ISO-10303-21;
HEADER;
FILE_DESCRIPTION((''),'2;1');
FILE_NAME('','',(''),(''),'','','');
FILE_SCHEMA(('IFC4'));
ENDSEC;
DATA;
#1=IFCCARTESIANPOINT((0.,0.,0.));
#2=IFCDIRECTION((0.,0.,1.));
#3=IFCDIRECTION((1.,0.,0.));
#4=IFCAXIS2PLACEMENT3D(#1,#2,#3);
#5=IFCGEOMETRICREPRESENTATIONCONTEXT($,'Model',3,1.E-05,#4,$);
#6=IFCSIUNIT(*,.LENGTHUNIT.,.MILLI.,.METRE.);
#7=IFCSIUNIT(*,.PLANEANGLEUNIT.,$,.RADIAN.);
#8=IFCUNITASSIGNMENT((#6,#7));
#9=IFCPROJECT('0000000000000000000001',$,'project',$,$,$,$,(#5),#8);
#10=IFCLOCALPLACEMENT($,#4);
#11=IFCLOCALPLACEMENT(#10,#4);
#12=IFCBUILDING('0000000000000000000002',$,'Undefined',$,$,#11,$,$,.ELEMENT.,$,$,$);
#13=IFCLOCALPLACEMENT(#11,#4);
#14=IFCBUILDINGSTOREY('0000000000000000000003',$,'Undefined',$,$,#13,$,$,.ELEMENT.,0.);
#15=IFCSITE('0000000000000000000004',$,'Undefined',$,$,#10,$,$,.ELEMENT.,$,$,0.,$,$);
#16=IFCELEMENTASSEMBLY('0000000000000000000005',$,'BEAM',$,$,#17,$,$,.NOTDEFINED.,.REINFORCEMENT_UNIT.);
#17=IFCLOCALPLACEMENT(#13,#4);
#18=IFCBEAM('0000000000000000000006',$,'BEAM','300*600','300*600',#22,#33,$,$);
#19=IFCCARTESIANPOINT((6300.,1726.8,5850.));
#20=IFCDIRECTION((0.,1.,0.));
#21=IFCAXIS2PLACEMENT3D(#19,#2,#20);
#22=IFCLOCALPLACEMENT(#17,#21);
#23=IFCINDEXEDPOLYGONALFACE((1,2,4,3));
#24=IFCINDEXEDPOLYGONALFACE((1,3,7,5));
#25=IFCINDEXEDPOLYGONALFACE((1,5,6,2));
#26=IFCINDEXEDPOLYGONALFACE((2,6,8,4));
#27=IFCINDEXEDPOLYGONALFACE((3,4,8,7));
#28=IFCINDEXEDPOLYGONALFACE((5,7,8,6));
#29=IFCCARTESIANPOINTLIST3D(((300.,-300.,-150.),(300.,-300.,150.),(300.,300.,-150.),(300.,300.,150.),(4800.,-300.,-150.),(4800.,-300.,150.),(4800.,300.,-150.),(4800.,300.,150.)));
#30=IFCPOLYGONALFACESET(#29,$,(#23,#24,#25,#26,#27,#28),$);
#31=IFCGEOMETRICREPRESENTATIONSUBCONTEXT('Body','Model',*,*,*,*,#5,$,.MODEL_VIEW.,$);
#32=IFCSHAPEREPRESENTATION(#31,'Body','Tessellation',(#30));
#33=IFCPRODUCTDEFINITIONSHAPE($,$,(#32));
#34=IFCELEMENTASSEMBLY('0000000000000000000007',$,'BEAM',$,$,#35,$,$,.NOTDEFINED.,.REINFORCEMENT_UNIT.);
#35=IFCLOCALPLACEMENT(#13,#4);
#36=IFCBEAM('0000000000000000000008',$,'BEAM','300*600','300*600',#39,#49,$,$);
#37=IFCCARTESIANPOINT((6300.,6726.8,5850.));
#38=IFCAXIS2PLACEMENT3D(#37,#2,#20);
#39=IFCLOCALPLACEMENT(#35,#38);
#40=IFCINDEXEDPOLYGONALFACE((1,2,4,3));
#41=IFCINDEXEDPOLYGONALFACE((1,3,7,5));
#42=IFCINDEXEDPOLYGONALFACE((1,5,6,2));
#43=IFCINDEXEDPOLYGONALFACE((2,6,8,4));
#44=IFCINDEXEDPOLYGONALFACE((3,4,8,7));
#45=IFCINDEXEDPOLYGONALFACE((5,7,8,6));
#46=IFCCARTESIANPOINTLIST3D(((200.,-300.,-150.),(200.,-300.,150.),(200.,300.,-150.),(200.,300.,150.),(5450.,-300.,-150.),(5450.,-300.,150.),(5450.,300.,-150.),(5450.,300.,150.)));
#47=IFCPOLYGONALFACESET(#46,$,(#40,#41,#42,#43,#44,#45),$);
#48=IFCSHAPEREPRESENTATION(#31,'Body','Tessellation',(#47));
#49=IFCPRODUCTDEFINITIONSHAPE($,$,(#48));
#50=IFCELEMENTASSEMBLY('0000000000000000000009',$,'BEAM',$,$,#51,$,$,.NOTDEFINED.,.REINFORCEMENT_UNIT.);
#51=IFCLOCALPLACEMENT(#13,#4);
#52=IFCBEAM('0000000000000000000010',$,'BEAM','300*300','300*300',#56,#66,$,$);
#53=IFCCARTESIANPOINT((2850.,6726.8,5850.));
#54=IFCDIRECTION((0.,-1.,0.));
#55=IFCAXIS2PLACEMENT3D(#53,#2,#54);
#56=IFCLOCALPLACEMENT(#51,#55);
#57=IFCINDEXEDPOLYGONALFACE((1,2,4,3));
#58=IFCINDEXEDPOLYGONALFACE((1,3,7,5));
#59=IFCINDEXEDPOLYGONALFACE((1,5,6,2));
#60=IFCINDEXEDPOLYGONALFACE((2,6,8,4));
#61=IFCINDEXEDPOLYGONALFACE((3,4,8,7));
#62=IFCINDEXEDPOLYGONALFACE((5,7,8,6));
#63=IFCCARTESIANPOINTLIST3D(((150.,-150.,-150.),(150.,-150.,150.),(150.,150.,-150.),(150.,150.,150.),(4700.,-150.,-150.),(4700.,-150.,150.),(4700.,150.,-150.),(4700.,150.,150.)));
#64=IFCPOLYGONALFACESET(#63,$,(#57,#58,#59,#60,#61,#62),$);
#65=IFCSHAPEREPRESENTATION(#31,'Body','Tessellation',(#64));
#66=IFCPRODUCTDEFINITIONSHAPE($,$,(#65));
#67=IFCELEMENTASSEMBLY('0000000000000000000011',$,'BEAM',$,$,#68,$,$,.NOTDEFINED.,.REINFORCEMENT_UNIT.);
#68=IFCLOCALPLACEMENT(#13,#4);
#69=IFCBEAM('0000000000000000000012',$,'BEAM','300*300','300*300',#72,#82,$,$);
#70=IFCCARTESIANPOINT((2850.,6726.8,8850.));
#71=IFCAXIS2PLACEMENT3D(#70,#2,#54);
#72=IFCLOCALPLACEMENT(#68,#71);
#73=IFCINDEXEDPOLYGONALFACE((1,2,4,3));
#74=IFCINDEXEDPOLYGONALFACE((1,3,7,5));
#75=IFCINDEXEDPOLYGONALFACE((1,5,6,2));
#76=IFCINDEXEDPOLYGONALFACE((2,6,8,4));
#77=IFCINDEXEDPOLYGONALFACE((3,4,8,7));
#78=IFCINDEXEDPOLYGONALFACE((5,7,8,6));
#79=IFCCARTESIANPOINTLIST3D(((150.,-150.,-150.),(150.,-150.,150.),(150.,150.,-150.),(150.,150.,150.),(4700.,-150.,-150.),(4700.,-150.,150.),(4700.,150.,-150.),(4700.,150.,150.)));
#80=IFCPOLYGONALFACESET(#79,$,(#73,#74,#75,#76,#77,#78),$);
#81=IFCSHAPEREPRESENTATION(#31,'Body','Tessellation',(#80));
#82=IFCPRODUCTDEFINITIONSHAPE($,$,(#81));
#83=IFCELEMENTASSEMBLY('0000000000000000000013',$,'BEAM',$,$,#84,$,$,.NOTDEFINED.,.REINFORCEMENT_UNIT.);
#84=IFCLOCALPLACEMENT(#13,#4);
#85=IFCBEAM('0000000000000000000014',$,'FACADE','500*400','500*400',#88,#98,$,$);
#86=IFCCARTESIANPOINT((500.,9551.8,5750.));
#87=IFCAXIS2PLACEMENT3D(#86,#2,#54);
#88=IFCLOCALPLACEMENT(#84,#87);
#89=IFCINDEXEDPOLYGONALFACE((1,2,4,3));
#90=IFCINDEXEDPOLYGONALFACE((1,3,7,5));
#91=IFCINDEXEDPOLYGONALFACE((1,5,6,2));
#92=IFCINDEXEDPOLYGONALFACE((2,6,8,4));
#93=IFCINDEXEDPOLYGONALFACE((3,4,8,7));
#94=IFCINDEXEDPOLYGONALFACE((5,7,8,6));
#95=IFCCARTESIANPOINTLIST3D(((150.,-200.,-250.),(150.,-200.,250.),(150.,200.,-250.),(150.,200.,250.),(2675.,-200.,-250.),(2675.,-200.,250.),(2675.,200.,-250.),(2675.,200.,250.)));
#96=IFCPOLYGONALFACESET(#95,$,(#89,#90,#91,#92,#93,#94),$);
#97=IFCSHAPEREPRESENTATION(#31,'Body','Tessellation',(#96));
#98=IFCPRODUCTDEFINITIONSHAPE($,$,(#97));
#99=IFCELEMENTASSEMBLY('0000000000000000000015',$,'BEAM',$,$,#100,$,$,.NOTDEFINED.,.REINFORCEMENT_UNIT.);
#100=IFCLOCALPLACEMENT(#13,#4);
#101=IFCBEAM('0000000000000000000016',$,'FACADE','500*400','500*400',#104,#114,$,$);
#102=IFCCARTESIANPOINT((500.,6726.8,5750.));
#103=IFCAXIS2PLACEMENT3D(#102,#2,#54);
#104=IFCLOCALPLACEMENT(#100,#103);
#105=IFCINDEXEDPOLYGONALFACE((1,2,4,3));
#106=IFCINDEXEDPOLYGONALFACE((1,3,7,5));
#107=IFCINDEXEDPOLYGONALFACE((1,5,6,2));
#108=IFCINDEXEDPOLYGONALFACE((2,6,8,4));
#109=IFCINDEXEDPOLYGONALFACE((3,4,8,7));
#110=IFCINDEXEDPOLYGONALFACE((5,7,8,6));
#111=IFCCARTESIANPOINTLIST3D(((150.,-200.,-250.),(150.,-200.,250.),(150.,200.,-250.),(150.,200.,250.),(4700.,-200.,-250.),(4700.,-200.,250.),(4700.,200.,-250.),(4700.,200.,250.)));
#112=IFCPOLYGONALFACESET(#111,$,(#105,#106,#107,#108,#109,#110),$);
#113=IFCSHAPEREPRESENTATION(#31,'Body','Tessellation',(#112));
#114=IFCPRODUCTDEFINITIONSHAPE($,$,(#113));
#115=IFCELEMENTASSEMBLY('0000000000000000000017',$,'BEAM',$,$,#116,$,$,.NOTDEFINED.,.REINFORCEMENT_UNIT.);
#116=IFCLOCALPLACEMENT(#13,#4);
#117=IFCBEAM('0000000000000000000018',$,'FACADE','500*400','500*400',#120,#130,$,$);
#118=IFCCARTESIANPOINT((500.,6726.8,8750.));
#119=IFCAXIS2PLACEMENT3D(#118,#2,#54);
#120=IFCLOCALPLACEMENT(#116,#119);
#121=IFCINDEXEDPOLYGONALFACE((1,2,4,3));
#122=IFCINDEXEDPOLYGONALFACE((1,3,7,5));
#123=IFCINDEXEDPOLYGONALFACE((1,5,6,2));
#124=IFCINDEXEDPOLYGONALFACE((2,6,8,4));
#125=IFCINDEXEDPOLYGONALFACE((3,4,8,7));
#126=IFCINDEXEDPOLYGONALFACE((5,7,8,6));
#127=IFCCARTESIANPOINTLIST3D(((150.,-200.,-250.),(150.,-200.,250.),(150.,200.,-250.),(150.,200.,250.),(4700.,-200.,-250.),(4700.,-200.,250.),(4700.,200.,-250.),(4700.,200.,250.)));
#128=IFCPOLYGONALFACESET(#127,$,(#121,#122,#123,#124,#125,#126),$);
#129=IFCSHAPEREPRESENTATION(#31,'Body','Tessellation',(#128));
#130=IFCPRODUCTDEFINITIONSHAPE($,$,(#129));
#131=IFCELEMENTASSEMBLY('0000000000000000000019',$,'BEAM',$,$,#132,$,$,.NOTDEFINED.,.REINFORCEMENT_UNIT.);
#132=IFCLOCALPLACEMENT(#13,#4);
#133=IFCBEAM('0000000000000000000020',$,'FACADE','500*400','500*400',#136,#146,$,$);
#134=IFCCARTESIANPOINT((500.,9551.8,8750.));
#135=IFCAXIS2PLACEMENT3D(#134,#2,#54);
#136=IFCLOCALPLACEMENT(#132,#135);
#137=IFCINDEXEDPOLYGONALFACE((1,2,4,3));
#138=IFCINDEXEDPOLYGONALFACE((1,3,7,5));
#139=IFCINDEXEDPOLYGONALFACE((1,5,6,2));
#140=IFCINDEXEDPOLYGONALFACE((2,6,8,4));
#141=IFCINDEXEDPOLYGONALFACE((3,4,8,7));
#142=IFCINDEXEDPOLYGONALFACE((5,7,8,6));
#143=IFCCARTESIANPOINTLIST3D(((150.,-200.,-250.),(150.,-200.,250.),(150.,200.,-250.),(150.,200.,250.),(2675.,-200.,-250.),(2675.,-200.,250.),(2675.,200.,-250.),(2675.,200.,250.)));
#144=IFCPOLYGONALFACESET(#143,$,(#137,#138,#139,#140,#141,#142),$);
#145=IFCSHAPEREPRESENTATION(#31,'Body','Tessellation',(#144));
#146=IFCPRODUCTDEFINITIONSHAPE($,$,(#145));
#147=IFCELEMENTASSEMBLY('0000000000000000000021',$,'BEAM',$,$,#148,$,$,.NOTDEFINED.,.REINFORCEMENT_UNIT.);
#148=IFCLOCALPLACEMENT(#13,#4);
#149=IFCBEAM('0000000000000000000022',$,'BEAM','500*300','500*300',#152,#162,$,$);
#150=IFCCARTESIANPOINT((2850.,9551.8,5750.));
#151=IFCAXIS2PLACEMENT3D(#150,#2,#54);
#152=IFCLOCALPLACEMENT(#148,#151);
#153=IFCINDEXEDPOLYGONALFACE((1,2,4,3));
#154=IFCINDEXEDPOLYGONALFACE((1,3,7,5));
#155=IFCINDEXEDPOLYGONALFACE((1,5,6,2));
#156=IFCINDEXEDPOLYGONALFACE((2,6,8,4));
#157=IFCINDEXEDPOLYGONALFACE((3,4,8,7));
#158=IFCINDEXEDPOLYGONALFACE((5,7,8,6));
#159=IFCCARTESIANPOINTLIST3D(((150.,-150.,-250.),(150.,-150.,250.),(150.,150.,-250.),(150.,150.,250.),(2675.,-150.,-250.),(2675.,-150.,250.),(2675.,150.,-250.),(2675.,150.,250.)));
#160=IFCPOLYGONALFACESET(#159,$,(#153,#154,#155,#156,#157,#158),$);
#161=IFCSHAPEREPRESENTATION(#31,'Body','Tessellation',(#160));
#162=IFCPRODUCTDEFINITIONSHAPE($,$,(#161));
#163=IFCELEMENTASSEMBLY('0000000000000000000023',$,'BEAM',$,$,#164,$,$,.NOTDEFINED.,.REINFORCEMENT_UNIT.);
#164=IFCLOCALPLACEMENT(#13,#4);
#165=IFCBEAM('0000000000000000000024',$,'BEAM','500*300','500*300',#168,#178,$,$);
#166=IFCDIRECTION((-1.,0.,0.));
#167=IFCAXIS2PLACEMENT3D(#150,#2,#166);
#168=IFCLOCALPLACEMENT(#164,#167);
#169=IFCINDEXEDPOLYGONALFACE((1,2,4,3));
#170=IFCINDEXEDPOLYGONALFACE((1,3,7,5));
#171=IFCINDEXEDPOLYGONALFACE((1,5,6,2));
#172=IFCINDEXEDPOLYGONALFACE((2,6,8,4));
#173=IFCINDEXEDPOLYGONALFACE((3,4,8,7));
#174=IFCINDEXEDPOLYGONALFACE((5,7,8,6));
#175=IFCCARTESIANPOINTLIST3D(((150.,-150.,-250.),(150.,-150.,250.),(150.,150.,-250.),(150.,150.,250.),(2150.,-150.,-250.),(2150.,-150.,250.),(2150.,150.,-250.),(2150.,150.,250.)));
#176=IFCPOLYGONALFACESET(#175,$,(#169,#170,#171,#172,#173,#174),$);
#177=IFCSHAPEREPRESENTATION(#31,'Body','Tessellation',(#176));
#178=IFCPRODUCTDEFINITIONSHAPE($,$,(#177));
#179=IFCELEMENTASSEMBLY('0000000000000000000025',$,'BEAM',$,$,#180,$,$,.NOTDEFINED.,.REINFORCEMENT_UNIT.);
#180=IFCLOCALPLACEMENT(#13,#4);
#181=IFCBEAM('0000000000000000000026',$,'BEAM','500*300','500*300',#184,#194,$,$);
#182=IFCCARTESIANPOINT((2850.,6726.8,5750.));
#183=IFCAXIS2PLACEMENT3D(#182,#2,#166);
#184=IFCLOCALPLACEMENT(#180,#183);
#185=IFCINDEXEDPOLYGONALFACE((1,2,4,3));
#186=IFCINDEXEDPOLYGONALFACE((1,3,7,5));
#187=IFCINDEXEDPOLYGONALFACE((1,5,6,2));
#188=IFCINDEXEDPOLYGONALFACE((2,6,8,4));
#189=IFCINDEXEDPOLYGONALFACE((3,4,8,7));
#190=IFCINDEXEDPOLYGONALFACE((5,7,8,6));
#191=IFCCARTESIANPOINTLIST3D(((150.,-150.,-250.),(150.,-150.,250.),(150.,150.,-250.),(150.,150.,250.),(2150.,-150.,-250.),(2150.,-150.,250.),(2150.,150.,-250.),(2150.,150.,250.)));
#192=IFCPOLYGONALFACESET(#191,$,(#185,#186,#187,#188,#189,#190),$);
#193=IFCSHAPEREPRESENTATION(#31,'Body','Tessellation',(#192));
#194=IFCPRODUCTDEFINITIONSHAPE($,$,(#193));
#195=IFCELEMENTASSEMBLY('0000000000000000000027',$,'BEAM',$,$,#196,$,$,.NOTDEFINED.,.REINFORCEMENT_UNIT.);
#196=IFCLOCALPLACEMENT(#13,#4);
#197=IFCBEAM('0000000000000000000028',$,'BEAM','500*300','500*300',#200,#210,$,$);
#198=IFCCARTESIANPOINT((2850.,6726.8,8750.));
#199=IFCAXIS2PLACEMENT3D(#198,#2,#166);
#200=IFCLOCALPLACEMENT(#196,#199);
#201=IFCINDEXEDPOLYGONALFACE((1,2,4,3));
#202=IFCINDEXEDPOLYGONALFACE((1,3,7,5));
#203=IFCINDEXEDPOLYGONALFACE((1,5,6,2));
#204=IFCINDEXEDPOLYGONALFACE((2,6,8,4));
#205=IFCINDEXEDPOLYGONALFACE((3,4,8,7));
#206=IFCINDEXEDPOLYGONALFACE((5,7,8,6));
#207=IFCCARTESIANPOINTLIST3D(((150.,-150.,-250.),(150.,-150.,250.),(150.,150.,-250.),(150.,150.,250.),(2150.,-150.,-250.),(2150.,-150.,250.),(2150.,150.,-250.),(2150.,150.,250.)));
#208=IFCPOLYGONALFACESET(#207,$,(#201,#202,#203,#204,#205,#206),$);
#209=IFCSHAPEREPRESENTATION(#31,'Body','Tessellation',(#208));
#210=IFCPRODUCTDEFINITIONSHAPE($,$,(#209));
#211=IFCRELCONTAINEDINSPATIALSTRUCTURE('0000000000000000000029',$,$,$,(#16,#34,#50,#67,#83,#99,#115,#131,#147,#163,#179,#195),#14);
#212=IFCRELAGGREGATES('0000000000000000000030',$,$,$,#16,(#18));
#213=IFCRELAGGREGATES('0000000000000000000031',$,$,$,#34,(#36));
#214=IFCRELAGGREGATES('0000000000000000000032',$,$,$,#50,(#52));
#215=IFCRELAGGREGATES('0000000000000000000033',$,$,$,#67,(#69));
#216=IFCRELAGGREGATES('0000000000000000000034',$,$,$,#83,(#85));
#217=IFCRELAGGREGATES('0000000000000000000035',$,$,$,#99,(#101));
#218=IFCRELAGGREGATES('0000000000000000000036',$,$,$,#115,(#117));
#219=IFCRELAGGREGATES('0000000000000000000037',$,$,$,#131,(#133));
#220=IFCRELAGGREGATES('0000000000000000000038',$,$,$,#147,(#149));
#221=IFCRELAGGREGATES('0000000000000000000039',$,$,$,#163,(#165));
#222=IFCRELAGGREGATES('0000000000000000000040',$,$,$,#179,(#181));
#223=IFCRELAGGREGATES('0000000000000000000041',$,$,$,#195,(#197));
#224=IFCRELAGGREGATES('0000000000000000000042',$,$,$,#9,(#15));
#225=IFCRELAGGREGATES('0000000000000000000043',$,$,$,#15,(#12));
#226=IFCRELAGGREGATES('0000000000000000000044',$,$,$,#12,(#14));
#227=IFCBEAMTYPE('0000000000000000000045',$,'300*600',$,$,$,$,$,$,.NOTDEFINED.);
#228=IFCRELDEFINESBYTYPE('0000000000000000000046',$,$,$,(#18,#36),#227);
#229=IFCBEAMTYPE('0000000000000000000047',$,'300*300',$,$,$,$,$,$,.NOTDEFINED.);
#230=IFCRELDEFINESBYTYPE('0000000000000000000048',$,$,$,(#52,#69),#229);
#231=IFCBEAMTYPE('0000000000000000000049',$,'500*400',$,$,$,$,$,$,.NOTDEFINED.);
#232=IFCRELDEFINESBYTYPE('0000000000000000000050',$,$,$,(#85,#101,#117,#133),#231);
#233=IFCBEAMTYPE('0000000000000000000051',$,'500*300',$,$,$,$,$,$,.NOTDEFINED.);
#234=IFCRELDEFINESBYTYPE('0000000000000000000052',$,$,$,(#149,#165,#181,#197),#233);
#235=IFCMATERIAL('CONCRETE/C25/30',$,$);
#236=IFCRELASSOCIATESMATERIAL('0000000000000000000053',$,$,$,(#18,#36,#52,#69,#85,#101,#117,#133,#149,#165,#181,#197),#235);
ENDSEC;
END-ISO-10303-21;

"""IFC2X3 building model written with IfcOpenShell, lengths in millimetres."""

from ifc_helpers import new_model, si_unit, frame, origin_with_axes, origin_2d_with_axis, place, context, subcontext, project, spatial, rectangle, extrude, material, type_object, element, aggregate, save


model = new_model("IFC2X3")

# Units and contexts
model_context = context("Model", 3, precision=1e-05, world=origin_with_axes())
body_context = subcontext(model_context, "Body", "Model", "MODEL_VIEW")
ifc_project = project(units=[si_unit("LENGTHUNIT", "METRE", prefix="MILLI"), si_unit("PLANEANGLEUNIT", "RADIAN")], contexts=[model_context])

# Site, building, storey
site_placement = place(None, origin_with_axes())
site = spatial("IfcSite", under=ifc_project, at=site_placement, Name="Undefined", CompositionType="ELEMENT", RefElevation=0.0)
building_placement = place(site_placement, origin_with_axes())
building = spatial("IfcBuilding", under=site, at=building_placement, Name="Undefined", CompositionType="ELEMENT")
storey_placement = place(building_placement, origin_with_axes())
storey = spatial("IfcBuildingStorey", under=building, at=storey_placement, Name="Undefined", CompositionType="ELEMENT", Elevation=0.0)

# Shared definitions
ifc_material_1 = material(Name="CONCRETE/C25/30")

# Element assemblies, beams
assembly_1_placement = place(storey_placement, origin_with_axes())
assembly_1 = element("IfcElementAssembly", 1, at=assembly_1_placement, inside=storey, Name="BEAM", AssemblyPlace="NOTDEFINED", PredefinedType="REINFORCEMENT_UNIT")
beam_type_1 = type_object("IfcBeamType", Name="300*600", PredefinedType="NOTDEFINED")
beam_1_placement = place(assembly_1_placement, frame((6300.0, 1726.8, 5850.0), z_axis=(0.0, 0.0, 1.0), x_axis=(0.0, 1.0, 0.0)))
beam_1 = element("IfcBeam", 2, at=beam_1_placement, type_object=beam_type_1, material=ifc_material_1, Name="BEAM", Description="300*600", ObjectType="300*600", context=body_context, shape_type="SweptSolid", body=[
    extrude(rectangle(XDim=600.0, YDim=300.0, at=origin_2d_with_axis()), frame((4800.0, 0.0, 0.0), z_axis=(-1.0, 0.0, 0.0), x_axis=(0.0, -1.0, 0.0)), (0.0, 0.0, 1.0), 4500.0),
])
aggregate(assembly_1, [beam_1])
assembly_2_placement = place(storey_placement, origin_with_axes())
assembly_2 = element("IfcElementAssembly", 3, at=assembly_2_placement, inside=storey, Name="BEAM", AssemblyPlace="NOTDEFINED", PredefinedType="REINFORCEMENT_UNIT")
beam_2_placement = place(assembly_2_placement, frame((6300.0, 6726.8, 5850.0), z_axis=(0.0, 0.0, 1.0), x_axis=(0.0, 1.0, 0.0)))
beam_2 = element("IfcBeam", 4, at=beam_2_placement, type_object=beam_type_1, material=ifc_material_1, Name="BEAM", Description="300*600", ObjectType="300*600", context=body_context, shape_type="SweptSolid", body=[
    extrude(rectangle(XDim=600.0, YDim=300.0, at=origin_2d_with_axis()), frame((5450.0, 0.0, 0.0), z_axis=(-1.0, 0.0, 0.0), x_axis=(0.0, -1.0, 0.0)), (0.0, 0.0, 1.0), 5250.0),
])
aggregate(assembly_2, [beam_2])
assembly_3_placement = place(storey_placement, origin_with_axes())
assembly_3 = element("IfcElementAssembly", 5, at=assembly_3_placement, inside=storey, Name="BEAM", AssemblyPlace="NOTDEFINED", PredefinedType="REINFORCEMENT_UNIT")
beam_type_2 = type_object("IfcBeamType", Name="300*300", PredefinedType="NOTDEFINED")
beam_3_placement = place(assembly_3_placement, frame((2850.0, 6726.8, 5850.0), z_axis=(0.0, 0.0, 1.0), x_axis=(0.0, -1.0, 0.0)))
beam_3 = element("IfcBeam", 6, at=beam_3_placement, type_object=beam_type_2, material=ifc_material_1, Name="BEAM", Description="300*300", ObjectType="300*300", context=body_context, shape_type="SweptSolid", body=[
    extrude(rectangle(XDim=300.0, YDim=300.0, at=origin_2d_with_axis()), frame((4700.0, 0.0, 0.0), z_axis=(-1.0, 0.0, 0.0), x_axis=(0.0, -1.0, 0.0)), (0.0, 0.0, 1.0), 4550.0),
])
aggregate(assembly_3, [beam_3])
assembly_4_placement = place(storey_placement, origin_with_axes())
assembly_4 = element("IfcElementAssembly", 7, at=assembly_4_placement, inside=storey, Name="BEAM", AssemblyPlace="NOTDEFINED", PredefinedType="REINFORCEMENT_UNIT")
beam_4_placement = place(assembly_4_placement, frame((2850.0, 6726.8, 8850.0), z_axis=(0.0, 0.0, 1.0), x_axis=(0.0, -1.0, 0.0)))
beam_4 = element("IfcBeam", 8, at=beam_4_placement, type_object=beam_type_2, material=ifc_material_1, Name="BEAM", Description="300*300", ObjectType="300*300", context=body_context, shape_type="SweptSolid", body=[
    extrude(rectangle(XDim=300.0, YDim=300.0, at=origin_2d_with_axis()), frame((4700.0, 0.0, 0.0), z_axis=(-1.0, 0.0, 0.0), x_axis=(0.0, -1.0, 0.0)), (0.0, 0.0, 1.0), 4550.0),
])
aggregate(assembly_4, [beam_4])
assembly_5_placement = place(storey_placement, origin_with_axes())
assembly_5 = element("IfcElementAssembly", 9, at=assembly_5_placement, inside=storey, Name="BEAM", AssemblyPlace="NOTDEFINED", PredefinedType="REINFORCEMENT_UNIT")
beam_type_3 = type_object("IfcBeamType", Name="500*400", PredefinedType="NOTDEFINED")
beam_5_placement = place(assembly_5_placement, frame((500.0, 9551.8, 5750.0), z_axis=(0.0, 0.0, 1.0), x_axis=(0.0, -1.0, 0.0)))
beam_5 = element("IfcBeam", 10, at=beam_5_placement, type_object=beam_type_3, material=ifc_material_1, Name="FACADE", Description="500*400", ObjectType="500*400", context=body_context, shape_type="SweptSolid", body=[
    extrude(rectangle(XDim=400.0, YDim=500.0, at=origin_2d_with_axis()), frame((2675.0, 0.0, 0.0), z_axis=(-1.0, 0.0, 0.0), x_axis=(0.0, -1.0, 0.0)), (0.0, 0.0, 1.0), 2525.0),
])
aggregate(assembly_5, [beam_5])
assembly_6_placement = place(storey_placement, origin_with_axes())
assembly_6 = element("IfcElementAssembly", 11, at=assembly_6_placement, inside=storey, Name="BEAM", AssemblyPlace="NOTDEFINED", PredefinedType="REINFORCEMENT_UNIT")
beam_6_placement = place(assembly_6_placement, frame((500.0, 6726.8, 5750.0), z_axis=(0.0, 0.0, 1.0), x_axis=(0.0, -1.0, 0.0)))
beam_6 = element("IfcBeam", 12, at=beam_6_placement, type_object=beam_type_3, material=ifc_material_1, Name="FACADE", Description="500*400", ObjectType="500*400", context=body_context, shape_type="SweptSolid", body=[
    extrude(rectangle(XDim=400.0, YDim=500.0, at=origin_2d_with_axis()), frame((4700.0, 0.0, 0.0), z_axis=(-1.0, 0.0, 0.0), x_axis=(0.0, -1.0, 0.0)), (0.0, 0.0, 1.0), 4550.0),
])
aggregate(assembly_6, [beam_6])
assembly_7_placement = place(storey_placement, origin_with_axes())
assembly_7 = element("IfcElementAssembly", 13, at=assembly_7_placement, inside=storey, Name="BEAM", AssemblyPlace="NOTDEFINED", PredefinedType="REINFORCEMENT_UNIT")
beam_7_placement = place(assembly_7_placement, frame((500.0, 6726.8, 8750.0), z_axis=(0.0, 0.0, 1.0), x_axis=(0.0, -1.0, 0.0)))
beam_7 = element("IfcBeam", 14, at=beam_7_placement, type_object=beam_type_3, material=ifc_material_1, Name="FACADE", Description="500*400", ObjectType="500*400", context=body_context, shape_type="SweptSolid", body=[
    extrude(rectangle(XDim=400.0, YDim=500.0, at=origin_2d_with_axis()), frame((4700.0, 0.0, 0.0), z_axis=(-1.0, 0.0, 0.0), x_axis=(0.0, -1.0, 0.0)), (0.0, 0.0, 1.0), 4550.0),
])
aggregate(assembly_7, [beam_7])
assembly_8_placement = place(storey_placement, origin_with_axes())
assembly_8 = element("IfcElementAssembly", 15, at=assembly_8_placement, inside=storey, Name="BEAM", AssemblyPlace="NOTDEFINED", PredefinedType="REINFORCEMENT_UNIT")
beam_8_placement = place(assembly_8_placement, frame((500.0, 9551.8, 8750.0), z_axis=(0.0, 0.0, 1.0), x_axis=(0.0, -1.0, 0.0)))
beam_8 = element("IfcBeam", 16, at=beam_8_placement, type_object=beam_type_3, material=ifc_material_1, Name="FACADE", Description="500*400", ObjectType="500*400", context=body_context, shape_type="SweptSolid", body=[
    extrude(rectangle(XDim=400.0, YDim=500.0, at=origin_2d_with_axis()), frame((2675.0, 0.0, 0.0), z_axis=(-1.0, 0.0, 0.0), x_axis=(0.0, -1.0, 0.0)), (0.0, 0.0, 1.0), 2525.0),
])
aggregate(assembly_8, [beam_8])
assembly_9_placement = place(storey_placement, origin_with_axes())
assembly_9 = element("IfcElementAssembly", 17, at=assembly_9_placement, inside=storey, Name="BEAM", AssemblyPlace="NOTDEFINED", PredefinedType="REINFORCEMENT_UNIT")
beam_type_4 = type_object("IfcBeamType", Name="500*300", PredefinedType="NOTDEFINED")
beam_9_placement = place(assembly_9_placement, frame((2850.0, 9551.8, 5750.0), z_axis=(0.0, 0.0, 1.0), x_axis=(0.0, -1.0, 0.0)))
beam_9 = element("IfcBeam", 18, at=beam_9_placement, type_object=beam_type_4, material=ifc_material_1, Name="BEAM", Description="500*300", ObjectType="500*300", context=body_context, shape_type="SweptSolid", body=[
    extrude(rectangle(XDim=300.0, YDim=500.0, at=origin_2d_with_axis()), frame((2675.0, 0.0, 0.0), z_axis=(-1.0, 0.0, 0.0), x_axis=(0.0, -1.0, 0.0)), (0.0, 0.0, 1.0), 2525.0),
])
aggregate(assembly_9, [beam_9])
assembly_10_placement = place(storey_placement, origin_with_axes())
assembly_10 = element("IfcElementAssembly", 19, at=assembly_10_placement, inside=storey, Name="BEAM", AssemblyPlace="NOTDEFINED", PredefinedType="REINFORCEMENT_UNIT")
beam_10_placement = place(assembly_10_placement, frame((2850.0, 9551.8, 5750.0), z_axis=(0.0, 0.0, 1.0), x_axis=(-1.0, 0.0, 0.0)))
beam_10 = element("IfcBeam", 20, at=beam_10_placement, type_object=beam_type_4, material=ifc_material_1, Name="BEAM", Description="500*300", ObjectType="500*300", context=body_context, shape_type="SweptSolid", body=[
    extrude(rectangle(XDim=300.0, YDim=500.0, at=origin_2d_with_axis()), frame((2150.0, 0.0, 0.0), z_axis=(-1.0, 0.0, 0.0), x_axis=(0.0, -1.0, 0.0)), (0.0, 0.0, 1.0), 2000.0),
])
aggregate(assembly_10, [beam_10])
assembly_11_placement = place(storey_placement, origin_with_axes())
assembly_11 = element("IfcElementAssembly", 21, at=assembly_11_placement, inside=storey, Name="BEAM", AssemblyPlace="NOTDEFINED", PredefinedType="REINFORCEMENT_UNIT")
beam_11_placement = place(assembly_11_placement, frame((2850.0, 6726.8, 5750.0), z_axis=(0.0, 0.0, 1.0), x_axis=(-1.0, 0.0, 0.0)))
beam_11 = element("IfcBeam", 22, at=beam_11_placement, type_object=beam_type_4, material=ifc_material_1, Name="BEAM", Description="500*300", ObjectType="500*300", context=body_context, shape_type="SweptSolid", body=[
    extrude(rectangle(XDim=300.0, YDim=500.0, at=origin_2d_with_axis()), frame((2150.0, 0.0, 0.0), z_axis=(-1.0, 0.0, 0.0), x_axis=(0.0, -1.0, 0.0)), (0.0, 0.0, 1.0), 2000.0),
])
aggregate(assembly_11, [beam_11])
assembly_12_placement = place(storey_placement, origin_with_axes())
assembly_12 = element("IfcElementAssembly", 23, at=assembly_12_placement, inside=storey, Name="BEAM", AssemblyPlace="NOTDEFINED", PredefinedType="REINFORCEMENT_UNIT")
beam_12_placement = place(assembly_12_placement, frame((2850.0, 6726.8, 8750.0), z_axis=(0.0, 0.0, 1.0), x_axis=(-1.0, 0.0, 0.0)))
beam_12 = element("IfcBeam", 24, at=beam_12_placement, type_object=beam_type_4, material=ifc_material_1, Name="BEAM", Description="500*300", ObjectType="500*300", context=body_context, shape_type="SweptSolid", body=[
    extrude(rectangle(XDim=300.0, YDim=500.0, at=origin_2d_with_axis()), frame((2150.0, 0.0, 0.0), z_axis=(-1.0, 0.0, 0.0), x_axis=(0.0, -1.0, 0.0)), (0.0, 0.0, 1.0), 2000.0),
])
aggregate(assembly_12, [beam_12])

save(model, "model.ifc")
